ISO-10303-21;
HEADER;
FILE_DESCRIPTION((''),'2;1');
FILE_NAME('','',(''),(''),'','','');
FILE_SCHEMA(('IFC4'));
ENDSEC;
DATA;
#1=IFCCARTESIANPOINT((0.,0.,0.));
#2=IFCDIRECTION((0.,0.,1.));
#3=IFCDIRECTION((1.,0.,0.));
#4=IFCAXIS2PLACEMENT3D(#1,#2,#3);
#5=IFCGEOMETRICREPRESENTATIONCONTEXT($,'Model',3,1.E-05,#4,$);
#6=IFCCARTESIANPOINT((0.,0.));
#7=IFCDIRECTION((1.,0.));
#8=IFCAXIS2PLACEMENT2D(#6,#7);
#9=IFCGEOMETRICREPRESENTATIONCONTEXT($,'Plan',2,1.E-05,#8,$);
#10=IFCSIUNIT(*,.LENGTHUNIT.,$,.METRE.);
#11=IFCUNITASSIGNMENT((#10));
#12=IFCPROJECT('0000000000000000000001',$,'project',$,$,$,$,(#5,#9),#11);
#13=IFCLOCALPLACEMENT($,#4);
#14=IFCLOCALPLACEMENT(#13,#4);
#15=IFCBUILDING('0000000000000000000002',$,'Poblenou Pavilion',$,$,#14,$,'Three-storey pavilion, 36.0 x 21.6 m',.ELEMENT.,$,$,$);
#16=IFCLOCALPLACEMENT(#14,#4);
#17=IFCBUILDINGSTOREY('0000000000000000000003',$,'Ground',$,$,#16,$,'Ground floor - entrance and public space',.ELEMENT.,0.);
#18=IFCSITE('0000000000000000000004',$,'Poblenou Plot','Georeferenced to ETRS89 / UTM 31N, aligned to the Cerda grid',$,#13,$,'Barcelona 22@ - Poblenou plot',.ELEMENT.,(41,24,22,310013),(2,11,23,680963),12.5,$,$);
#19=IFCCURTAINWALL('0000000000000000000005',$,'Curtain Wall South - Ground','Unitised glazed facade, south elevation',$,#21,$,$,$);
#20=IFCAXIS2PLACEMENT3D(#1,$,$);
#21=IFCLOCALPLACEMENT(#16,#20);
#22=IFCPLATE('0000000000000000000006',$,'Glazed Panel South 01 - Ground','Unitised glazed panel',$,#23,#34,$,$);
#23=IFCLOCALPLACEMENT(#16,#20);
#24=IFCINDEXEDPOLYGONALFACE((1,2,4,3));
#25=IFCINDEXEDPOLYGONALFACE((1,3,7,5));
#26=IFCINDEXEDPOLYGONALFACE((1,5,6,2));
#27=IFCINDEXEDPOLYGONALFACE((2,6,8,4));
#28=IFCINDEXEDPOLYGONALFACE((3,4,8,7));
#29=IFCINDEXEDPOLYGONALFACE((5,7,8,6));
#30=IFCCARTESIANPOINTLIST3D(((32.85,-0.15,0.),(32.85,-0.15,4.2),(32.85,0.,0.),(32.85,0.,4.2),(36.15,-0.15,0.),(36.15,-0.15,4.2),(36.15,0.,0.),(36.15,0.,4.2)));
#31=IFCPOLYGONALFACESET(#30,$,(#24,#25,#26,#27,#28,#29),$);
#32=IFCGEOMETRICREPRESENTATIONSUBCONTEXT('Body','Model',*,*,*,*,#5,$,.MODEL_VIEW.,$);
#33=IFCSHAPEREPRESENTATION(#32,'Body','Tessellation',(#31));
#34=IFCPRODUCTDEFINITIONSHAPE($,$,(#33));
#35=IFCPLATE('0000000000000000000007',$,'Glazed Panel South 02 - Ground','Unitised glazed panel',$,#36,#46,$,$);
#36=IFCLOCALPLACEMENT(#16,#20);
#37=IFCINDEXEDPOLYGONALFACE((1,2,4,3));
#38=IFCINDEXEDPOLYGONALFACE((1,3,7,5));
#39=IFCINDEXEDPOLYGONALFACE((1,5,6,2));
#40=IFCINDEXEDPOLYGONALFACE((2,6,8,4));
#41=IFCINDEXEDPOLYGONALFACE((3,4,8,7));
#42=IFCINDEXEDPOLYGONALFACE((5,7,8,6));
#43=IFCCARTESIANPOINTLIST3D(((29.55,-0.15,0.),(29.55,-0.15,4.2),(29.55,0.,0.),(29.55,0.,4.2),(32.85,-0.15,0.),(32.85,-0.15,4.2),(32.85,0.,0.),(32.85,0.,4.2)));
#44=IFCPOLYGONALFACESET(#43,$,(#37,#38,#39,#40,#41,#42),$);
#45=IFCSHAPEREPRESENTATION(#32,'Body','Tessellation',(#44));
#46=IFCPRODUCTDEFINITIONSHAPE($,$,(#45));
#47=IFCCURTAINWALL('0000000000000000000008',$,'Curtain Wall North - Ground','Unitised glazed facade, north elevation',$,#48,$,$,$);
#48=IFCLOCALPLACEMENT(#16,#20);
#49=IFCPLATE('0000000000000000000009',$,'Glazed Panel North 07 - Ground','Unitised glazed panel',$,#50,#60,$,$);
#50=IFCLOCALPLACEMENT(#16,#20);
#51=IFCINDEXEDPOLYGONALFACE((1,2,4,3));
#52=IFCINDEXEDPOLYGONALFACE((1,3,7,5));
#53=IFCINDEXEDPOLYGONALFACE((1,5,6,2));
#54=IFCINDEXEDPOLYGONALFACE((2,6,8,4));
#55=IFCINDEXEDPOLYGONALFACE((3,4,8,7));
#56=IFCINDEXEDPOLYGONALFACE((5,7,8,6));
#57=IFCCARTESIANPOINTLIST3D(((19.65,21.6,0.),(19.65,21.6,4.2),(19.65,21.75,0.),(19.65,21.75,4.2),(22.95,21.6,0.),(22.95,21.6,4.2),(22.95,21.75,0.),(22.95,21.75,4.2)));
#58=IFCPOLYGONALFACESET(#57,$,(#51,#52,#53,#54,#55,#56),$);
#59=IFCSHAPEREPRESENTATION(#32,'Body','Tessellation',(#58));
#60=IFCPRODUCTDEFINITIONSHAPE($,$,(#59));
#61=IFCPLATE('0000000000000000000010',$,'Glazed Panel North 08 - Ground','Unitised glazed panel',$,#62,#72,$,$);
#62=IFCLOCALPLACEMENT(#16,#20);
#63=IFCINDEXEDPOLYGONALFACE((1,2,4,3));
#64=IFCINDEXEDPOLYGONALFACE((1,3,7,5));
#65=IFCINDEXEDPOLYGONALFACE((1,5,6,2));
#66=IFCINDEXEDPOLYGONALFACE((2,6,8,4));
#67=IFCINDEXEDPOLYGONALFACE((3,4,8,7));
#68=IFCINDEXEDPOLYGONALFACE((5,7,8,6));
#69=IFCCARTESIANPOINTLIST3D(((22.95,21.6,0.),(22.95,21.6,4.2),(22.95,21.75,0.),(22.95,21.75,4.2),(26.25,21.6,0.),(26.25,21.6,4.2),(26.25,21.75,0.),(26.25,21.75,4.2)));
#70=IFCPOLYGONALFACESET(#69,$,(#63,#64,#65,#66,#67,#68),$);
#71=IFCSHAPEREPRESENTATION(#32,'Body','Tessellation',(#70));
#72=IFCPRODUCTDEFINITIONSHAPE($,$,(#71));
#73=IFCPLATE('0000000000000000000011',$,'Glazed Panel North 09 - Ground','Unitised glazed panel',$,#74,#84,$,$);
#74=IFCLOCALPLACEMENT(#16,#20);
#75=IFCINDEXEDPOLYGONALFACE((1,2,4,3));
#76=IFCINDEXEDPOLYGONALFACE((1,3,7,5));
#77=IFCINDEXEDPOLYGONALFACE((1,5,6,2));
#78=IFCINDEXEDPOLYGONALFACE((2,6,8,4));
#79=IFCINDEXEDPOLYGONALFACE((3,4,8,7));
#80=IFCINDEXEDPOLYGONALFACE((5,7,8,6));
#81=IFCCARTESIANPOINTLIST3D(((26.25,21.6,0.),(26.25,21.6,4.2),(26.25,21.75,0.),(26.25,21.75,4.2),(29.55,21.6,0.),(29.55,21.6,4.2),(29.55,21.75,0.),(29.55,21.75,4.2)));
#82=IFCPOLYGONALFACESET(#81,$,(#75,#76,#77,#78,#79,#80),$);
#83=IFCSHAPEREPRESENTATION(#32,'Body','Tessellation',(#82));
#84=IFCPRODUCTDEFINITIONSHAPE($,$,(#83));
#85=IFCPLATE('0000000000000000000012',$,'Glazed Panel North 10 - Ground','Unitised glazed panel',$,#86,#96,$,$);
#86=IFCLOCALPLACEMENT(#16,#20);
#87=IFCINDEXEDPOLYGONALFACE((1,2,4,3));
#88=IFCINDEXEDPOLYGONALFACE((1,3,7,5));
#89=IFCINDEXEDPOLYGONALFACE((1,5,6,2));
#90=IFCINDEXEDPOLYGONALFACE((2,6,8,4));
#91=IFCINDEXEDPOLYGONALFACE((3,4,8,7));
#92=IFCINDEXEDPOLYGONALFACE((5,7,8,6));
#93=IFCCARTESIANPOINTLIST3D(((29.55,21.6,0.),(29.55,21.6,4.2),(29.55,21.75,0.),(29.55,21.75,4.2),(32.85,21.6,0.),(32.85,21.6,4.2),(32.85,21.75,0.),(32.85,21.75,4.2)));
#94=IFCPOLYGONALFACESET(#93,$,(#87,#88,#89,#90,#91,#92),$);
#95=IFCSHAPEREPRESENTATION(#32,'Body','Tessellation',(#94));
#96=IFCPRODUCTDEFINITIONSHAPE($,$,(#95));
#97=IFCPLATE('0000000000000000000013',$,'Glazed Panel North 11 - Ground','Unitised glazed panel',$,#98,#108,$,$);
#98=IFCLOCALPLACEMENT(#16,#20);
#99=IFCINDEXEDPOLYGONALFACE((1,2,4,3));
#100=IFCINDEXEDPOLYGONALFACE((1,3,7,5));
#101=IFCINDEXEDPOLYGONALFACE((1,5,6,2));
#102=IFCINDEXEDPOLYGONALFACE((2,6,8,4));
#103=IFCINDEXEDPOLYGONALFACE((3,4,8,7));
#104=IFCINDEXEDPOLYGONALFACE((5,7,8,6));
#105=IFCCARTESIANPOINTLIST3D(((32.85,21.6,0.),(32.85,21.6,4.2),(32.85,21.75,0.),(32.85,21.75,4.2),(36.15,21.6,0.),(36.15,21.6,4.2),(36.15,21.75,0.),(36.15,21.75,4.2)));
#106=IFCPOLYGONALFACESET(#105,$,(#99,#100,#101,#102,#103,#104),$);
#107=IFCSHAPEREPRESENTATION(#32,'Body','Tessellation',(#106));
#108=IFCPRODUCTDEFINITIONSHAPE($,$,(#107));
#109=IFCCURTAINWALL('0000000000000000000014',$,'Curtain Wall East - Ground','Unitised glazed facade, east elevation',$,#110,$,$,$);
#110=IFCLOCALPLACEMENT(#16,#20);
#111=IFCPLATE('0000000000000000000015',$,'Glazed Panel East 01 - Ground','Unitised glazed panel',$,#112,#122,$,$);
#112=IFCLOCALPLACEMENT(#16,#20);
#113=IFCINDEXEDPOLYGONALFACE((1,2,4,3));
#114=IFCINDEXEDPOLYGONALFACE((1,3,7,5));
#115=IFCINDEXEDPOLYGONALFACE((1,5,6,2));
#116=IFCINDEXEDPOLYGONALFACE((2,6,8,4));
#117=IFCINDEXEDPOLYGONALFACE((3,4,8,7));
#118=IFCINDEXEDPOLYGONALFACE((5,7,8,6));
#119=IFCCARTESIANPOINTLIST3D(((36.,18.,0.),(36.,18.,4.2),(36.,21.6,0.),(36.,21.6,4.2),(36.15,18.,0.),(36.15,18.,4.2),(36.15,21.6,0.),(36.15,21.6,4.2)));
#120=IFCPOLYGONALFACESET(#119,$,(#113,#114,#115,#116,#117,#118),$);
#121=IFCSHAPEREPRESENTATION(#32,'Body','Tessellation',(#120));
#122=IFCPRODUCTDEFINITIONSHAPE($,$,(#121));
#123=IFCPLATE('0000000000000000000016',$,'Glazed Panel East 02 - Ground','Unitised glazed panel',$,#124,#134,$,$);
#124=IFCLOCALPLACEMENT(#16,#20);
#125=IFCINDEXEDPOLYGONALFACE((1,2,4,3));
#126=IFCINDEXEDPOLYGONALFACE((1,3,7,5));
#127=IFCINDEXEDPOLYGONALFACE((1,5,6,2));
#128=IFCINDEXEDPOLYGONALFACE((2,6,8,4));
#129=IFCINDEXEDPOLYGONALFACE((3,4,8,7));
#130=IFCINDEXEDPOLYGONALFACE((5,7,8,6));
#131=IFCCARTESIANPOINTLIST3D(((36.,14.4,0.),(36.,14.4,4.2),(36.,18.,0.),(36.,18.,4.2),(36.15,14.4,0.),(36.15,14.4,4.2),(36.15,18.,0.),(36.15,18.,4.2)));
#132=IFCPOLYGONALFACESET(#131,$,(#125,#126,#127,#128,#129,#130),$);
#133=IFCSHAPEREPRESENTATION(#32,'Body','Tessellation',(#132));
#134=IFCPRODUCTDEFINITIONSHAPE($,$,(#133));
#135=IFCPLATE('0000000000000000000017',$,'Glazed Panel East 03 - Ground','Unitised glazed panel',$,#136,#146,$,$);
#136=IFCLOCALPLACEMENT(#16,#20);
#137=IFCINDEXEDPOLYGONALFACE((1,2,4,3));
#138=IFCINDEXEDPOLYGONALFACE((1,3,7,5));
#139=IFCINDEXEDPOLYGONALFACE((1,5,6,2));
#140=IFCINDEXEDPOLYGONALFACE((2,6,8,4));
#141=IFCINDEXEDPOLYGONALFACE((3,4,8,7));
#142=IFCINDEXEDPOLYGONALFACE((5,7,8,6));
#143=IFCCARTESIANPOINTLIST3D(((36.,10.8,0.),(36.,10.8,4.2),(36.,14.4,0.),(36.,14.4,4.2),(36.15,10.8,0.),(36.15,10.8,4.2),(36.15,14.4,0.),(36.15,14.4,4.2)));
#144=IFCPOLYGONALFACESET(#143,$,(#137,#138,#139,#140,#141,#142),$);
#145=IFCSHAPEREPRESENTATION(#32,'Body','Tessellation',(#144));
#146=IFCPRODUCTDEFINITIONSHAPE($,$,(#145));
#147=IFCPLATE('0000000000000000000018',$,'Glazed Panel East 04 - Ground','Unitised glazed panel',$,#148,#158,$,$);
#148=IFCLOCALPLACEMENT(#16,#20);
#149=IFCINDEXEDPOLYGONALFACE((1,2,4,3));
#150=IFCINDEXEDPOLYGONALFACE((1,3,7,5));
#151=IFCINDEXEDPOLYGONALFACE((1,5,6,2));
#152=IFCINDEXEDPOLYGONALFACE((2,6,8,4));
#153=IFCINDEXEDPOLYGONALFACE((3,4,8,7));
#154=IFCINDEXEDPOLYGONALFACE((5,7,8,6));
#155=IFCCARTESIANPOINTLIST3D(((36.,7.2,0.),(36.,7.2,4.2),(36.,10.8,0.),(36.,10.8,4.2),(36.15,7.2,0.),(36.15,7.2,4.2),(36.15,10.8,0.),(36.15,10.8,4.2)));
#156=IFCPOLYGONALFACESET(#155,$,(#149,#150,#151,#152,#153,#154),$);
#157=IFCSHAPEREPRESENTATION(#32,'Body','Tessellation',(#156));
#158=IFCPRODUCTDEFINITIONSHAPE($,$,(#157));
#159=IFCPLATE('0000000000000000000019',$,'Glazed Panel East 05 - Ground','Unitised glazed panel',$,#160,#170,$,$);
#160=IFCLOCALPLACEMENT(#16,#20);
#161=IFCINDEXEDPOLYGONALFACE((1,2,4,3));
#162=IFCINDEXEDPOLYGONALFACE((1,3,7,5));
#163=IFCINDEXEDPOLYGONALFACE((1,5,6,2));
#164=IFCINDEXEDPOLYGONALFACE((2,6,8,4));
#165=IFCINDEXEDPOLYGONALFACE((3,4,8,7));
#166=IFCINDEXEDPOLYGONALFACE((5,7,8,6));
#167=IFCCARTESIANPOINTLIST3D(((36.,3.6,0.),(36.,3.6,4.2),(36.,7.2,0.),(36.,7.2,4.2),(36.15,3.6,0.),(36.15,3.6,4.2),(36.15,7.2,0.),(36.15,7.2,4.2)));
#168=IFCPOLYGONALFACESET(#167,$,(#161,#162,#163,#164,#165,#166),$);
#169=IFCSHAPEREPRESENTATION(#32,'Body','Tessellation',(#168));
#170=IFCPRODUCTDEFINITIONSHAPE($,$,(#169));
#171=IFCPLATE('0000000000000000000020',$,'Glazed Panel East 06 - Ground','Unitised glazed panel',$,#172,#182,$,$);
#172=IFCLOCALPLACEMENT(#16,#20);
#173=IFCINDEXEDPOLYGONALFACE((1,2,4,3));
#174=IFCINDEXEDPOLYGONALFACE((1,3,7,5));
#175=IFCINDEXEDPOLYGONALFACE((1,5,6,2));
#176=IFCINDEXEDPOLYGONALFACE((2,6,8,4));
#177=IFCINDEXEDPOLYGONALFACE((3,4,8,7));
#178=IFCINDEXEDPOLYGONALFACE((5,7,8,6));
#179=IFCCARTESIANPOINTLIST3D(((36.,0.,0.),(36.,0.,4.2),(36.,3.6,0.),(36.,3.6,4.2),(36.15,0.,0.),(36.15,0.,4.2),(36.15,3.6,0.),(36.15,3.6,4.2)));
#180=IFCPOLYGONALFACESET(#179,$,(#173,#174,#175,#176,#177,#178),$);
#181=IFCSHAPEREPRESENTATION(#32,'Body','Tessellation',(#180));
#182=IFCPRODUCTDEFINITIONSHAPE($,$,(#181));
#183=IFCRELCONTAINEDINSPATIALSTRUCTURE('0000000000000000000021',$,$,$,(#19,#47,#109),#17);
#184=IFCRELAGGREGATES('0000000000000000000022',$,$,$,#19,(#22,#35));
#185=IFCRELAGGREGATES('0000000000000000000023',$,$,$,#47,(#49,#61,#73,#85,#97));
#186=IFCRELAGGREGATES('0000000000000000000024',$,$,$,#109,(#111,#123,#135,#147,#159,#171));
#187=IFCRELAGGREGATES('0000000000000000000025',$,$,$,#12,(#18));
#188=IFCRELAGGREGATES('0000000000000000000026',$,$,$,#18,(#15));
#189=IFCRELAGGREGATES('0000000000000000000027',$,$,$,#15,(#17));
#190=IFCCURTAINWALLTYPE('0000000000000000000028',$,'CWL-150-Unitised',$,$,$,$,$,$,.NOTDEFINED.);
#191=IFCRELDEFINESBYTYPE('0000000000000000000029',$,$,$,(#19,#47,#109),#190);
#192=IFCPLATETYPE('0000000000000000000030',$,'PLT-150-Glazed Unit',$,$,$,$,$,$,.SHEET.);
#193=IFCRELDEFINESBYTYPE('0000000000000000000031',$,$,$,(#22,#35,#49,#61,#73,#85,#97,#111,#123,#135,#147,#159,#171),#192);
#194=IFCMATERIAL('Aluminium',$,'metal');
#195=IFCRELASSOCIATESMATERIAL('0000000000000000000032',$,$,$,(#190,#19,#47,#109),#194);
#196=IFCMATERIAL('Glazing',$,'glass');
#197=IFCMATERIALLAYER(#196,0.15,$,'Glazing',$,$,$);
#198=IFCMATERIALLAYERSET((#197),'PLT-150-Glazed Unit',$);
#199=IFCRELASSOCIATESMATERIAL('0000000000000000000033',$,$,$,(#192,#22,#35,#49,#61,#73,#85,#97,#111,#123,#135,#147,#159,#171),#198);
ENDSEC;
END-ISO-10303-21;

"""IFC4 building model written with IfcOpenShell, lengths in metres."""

from ifc_helpers import new_model, si_unit, frame, origin_with_axes, origin_2d_with_axis, place, context, subcontext, project, spatial, line, indexed_curve, outline, extrude, material, layer, layer_set, layer_usage, type_object, element, aggregate, save


model = new_model("IFC4")

# Units and contexts
model_context = context("Model", 3, precision=1e-05, world=origin_with_axes())
plan_context = context("Plan", 2, precision=1e-05, world=origin_2d_with_axis())
body_context = subcontext(model_context, "Body", "Model", "MODEL_VIEW")
ifc_project = project(units=[si_unit("LENGTHUNIT", "METRE")], contexts=[model_context, plan_context])

# Site, building, storey
site_placement = place(None, origin_with_axes())
site = spatial("IfcSite", under=ifc_project, at=site_placement, Name="Poblenou Plot", Description="Georeferenced to ETRS89 / UTM 31N, aligned to the Cerda grid", LongName="Barcelona 22@ - Poblenou plot", CompositionType="ELEMENT", RefLatitude=(41, 24, 22, 310013), RefLongitude=(2, 11, 23, 680963), RefElevation=12.5)
building_placement = place(site_placement, origin_with_axes())
building = spatial("IfcBuilding", under=site, at=building_placement, Name="Poblenou Pavilion", LongName="Three-storey pavilion, 36.0 x 21.6 m", CompositionType="ELEMENT")
storey_placement = place(building_placement, origin_with_axes())
storey = spatial("IfcBuildingStorey", under=building, at=storey_placement, Name="Ground", LongName="Ground floor - entrance and public space", CompositionType="ELEMENT", Elevation=0.0)

# Curtain walls, plates
ifc_material_1 = material(Name="Aluminium", Category="metal")
curtain_wall_type = type_object("IfcCurtainWallType", Name="CWL-150-Unitised", PredefinedType="NOTDEFINED", material=ifc_material_1)
curtain_wall_1_placement = place(storey_placement, frame((36.15, 0.0, 0.0), z_axis=(0.0, 0.0, 1.0), x_axis=(-1.0, 0.0, 0.0)))
curtain_wall_1 = element("IfcCurtainWall", 1, at=curtain_wall_1_placement, inside=storey, type_object=curtain_wall_type, material=ifc_material_1, Name="Curtain Wall South - Ground", Description="Unitised glazed facade, south elevation")
ifc_material_2 = material(Name="Glazing", Category="glass")
ifc_layer_1 = layer(ifc_material_2, 0.15, Name="Glazing")
ifc_layer_set_1 = layer_set([ifc_layer_1], Name="PLT-150-Glazed Unit")
ifc_layer_usage_1 = layer_usage(ifc_layer_set_1, "AXIS2", "POSITIVE", 0.0)
plate_type = type_object("IfcPlateType", Name="PLT-150-Glazed Unit", PredefinedType="SHEET", material=ifc_layer_set_1)
plate_1_placement = place(curtain_wall_1_placement, origin_with_axes())
plate_1 = element("IfcPlate", 2, at=plate_1_placement, type_object=plate_type, material=ifc_layer_usage_1, Name="Glazed Panel South 01 - Ground", Description="Unitised glazed panel", context=body_context, shape_type="SweptSolid", body=[
    extrude(outline(indexed_curve([(0.0, 0.0), (3.3, 0.0), (3.3, 0.15), (0.0, 0.15)], segments=[line(1, 2, 3, 4, 1)])), origin_with_axes(), (0.0, 0.0, 1.0), 4.2),
])
ifc_layer_usage_2 = layer_usage(ifc_layer_set_1, "AXIS2", "POSITIVE", 0.0)
plate_2_placement = place(curtain_wall_1_placement, frame((3.3, 0.0, 0.0), z_axis=(0.0, 0.0, 1.0), x_axis=(1.0, 0.0, 0.0)))
plate_2 = element("IfcPlate", 3, at=plate_2_placement, type_object=plate_type, material=ifc_layer_usage_2, Name="Glazed Panel South 02 - Ground", Description="Unitised glazed panel", context=body_context, shape_type="SweptSolid", body=[
    extrude(outline(indexed_curve([(0.0, 0.0), (3.3, 0.0), (3.3, 0.15), (0.0, 0.15)], segments=[line(1, 2, 3, 4, 1)])), origin_with_axes(), (0.0, 0.0, 1.0), 4.2),
])
aggregate(curtain_wall_1, [plate_1, plate_2])
curtain_wall_2_placement = place(storey_placement, frame((-0.15, 21.6, 0.0), z_axis=(0.0, 0.0, 1.0), x_axis=(1.0, 0.0, 0.0)))
curtain_wall_2 = element("IfcCurtainWall", 4, at=curtain_wall_2_placement, inside=storey, type_object=curtain_wall_type, material=ifc_material_1, Name="Curtain Wall North - Ground", Description="Unitised glazed facade, north elevation")
ifc_layer_usage_3 = layer_usage(ifc_layer_set_1, "AXIS2", "POSITIVE", 0.0)
plate_3_placement = place(curtain_wall_2_placement, frame((19.8, 0.0, 0.0), z_axis=(0.0, 0.0, 1.0), x_axis=(1.0, 0.0, 0.0)))
plate_3 = element("IfcPlate", 5, at=plate_3_placement, type_object=plate_type, material=ifc_layer_usage_3, Name="Glazed Panel North 07 - Ground", Description="Unitised glazed panel", context=body_context, shape_type="SweptSolid", body=[
    extrude(outline(indexed_curve([(0.0, 0.0), (3.3, 0.0), (3.3, 0.15), (0.0, 0.15)], segments=[line(1, 2, 3, 4, 1)])), origin_with_axes(), (0.0, 0.0, 1.0), 4.2),
])
ifc_layer_usage_4 = layer_usage(ifc_layer_set_1, "AXIS2", "POSITIVE", 0.0)
plate_4_placement = place(curtain_wall_2_placement, frame((23.1, 0.0, 0.0), z_axis=(0.0, 0.0, 1.0), x_axis=(1.0, 0.0, 0.0)))
plate_4 = element("IfcPlate", 6, at=plate_4_placement, type_object=plate_type, material=ifc_layer_usage_4, Name="Glazed Panel North 08 - Ground", Description="Unitised glazed panel", context=body_context, shape_type="SweptSolid", body=[
    extrude(outline(indexed_curve([(0.0, 0.0), (3.3, 0.0), (3.3, 0.15), (0.0, 0.15)], segments=[line(1, 2, 3, 4, 1)])), origin_with_axes(), (0.0, 0.0, 1.0), 4.2),
])
ifc_layer_usage_5 = layer_usage(ifc_layer_set_1, "AXIS2", "POSITIVE", 0.0)
plate_5_placement = place(curtain_wall_2_placement, frame((26.4, 0.0, 0.0), z_axis=(0.0, 0.0, 1.0), x_axis=(1.0, 0.0, 0.0)))
plate_5 = element("IfcPlate", 7, at=plate_5_placement, type_object=plate_type, material=ifc_layer_usage_5, Name="Glazed Panel North 09 - Ground", Description="Unitised glazed panel", context=body_context, shape_type="SweptSolid", body=[
    extrude(outline(indexed_curve([(0.0, 0.0), (3.3, 0.0), (3.3, 0.15), (0.0, 0.15)], segments=[line(1, 2, 3, 4, 1)])), origin_with_axes(), (0.0, 0.0, 1.0), 4.2),
])
ifc_layer_usage_6 = layer_usage(ifc_layer_set_1, "AXIS2", "POSITIVE", 0.0)
plate_6_placement = place(curtain_wall_2_placement, frame((29.7, 0.0, 0.0), z_axis=(0.0, 0.0, 1.0), x_axis=(1.0, 0.0, 0.0)))
plate_6 = element("IfcPlate", 8, at=plate_6_placement, type_object=plate_type, material=ifc_layer_usage_6, Name="Glazed Panel North 10 - Ground", Description="Unitised glazed panel", context=body_context, shape_type="SweptSolid", body=[
    extrude(outline(indexed_curve([(0.0, 0.0), (3.3, 0.0), (3.3, 0.15), (0.0, 0.15)], segments=[line(1, 2, 3, 4, 1)])), origin_with_axes(), (0.0, 0.0, 1.0), 4.2),
])
ifc_layer_usage_7 = layer_usage(ifc_layer_set_1, "AXIS2", "POSITIVE", 0.0)
plate_7_placement = place(curtain_wall_2_placement, frame((33.0, 0.0, 0.0), z_axis=(0.0, 0.0, 1.0), x_axis=(1.0, 0.0, 0.0)))
plate_7 = element("IfcPlate", 9, at=plate_7_placement, type_object=plate_type, material=ifc_layer_usage_7, Name="Glazed Panel North 11 - Ground", Description="Unitised glazed panel", context=body_context, shape_type="SweptSolid", body=[
    extrude(outline(indexed_curve([(0.0, 0.0), (3.3, 0.0), (3.3, 0.15), (0.0, 0.15)], segments=[line(1, 2, 3, 4, 1)])), origin_with_axes(), (0.0, 0.0, 1.0), 4.2),
])
aggregate(curtain_wall_2, [plate_3, plate_4, plate_5, plate_6, plate_7])
curtain_wall_3_placement = place(storey_placement, frame((36.0, 21.6, 0.0), z_axis=(0.0, 0.0, 1.0), x_axis=(0.0, -1.0, 0.0)))
curtain_wall_3 = element("IfcCurtainWall", 10, at=curtain_wall_3_placement, inside=storey, type_object=curtain_wall_type, material=ifc_material_1, Name="Curtain Wall East - Ground", Description="Unitised glazed facade, east elevation")
ifc_layer_usage_8 = layer_usage(ifc_layer_set_1, "AXIS2", "POSITIVE", 0.0)
plate_8_placement = place(curtain_wall_3_placement, origin_with_axes())
plate_8 = element("IfcPlate", 11, at=plate_8_placement, type_object=plate_type, material=ifc_layer_usage_8, Name="Glazed Panel East 01 - Ground", Description="Unitised glazed panel", context=body_context, shape_type="SweptSolid", body=[
    extrude(outline(indexed_curve([(0.0, 0.0), (3.6, 0.0), (3.6, 0.15), (0.0, 0.15)], segments=[line(1, 2, 3, 4, 1)])), origin_with_axes(), (0.0, 0.0, 1.0), 4.2),
])
ifc_layer_usage_9 = layer_usage(ifc_layer_set_1, "AXIS2", "POSITIVE", 0.0)
plate_9_placement = place(curtain_wall_3_placement, frame((3.6, 0.0, 0.0), z_axis=(0.0, 0.0, 1.0), x_axis=(1.0, 0.0, 0.0)))
plate_9 = element("IfcPlate", 12, at=plate_9_placement, type_object=plate_type, material=ifc_layer_usage_9, Name="Glazed Panel East 02 - Ground", Description="Unitised glazed panel", context=body_context, shape_type="SweptSolid", body=[
    extrude(outline(indexed_curve([(0.0, 0.0), (3.6, 0.0), (3.6, 0.15), (0.0, 0.15)], segments=[line(1, 2, 3, 4, 1)])), origin_with_axes(), (0.0, 0.0, 1.0), 4.2),
])
ifc_layer_usage_10 = layer_usage(ifc_layer_set_1, "AXIS2", "POSITIVE", 0.0)
plate_10_placement = place(curtain_wall_3_placement, frame((7.2, 0.0, 0.0), z_axis=(0.0, 0.0, 1.0), x_axis=(1.0, 0.0, 0.0)))
plate_10 = element("IfcPlate", 13, at=plate_10_placement, type_object=plate_type, material=ifc_layer_usage_10, Name="Glazed Panel East 03 - Ground", Description="Unitised glazed panel", context=body_context, shape_type="SweptSolid", body=[
    extrude(outline(indexed_curve([(0.0, 0.0), (3.6, 0.0), (3.6, 0.15), (0.0, 0.15)], segments=[line(1, 2, 3, 4, 1)])), origin_with_axes(), (0.0, 0.0, 1.0), 4.2),
])
ifc_layer_usage_11 = layer_usage(ifc_layer_set_1, "AXIS2", "POSITIVE", 0.0)
plate_11_placement = place(curtain_wall_3_placement, frame((10.8, 0.0, 0.0), z_axis=(0.0, 0.0, 1.0), x_axis=(1.0, 0.0, 0.0)))
plate_11 = element("IfcPlate", 14, at=plate_11_placement, type_object=plate_type, material=ifc_layer_usage_11, Name="Glazed Panel East 04 - Ground", Description="Unitised glazed panel", context=body_context, shape_type="SweptSolid", body=[
    extrude(outline(indexed_curve([(0.0, 0.0), (3.6, 0.0), (3.6, 0.15), (0.0, 0.15)], segments=[line(1, 2, 3, 4, 1)])), origin_with_axes(), (0.0, 0.0, 1.0), 4.2),
])
ifc_layer_usage_12 = layer_usage(ifc_layer_set_1, "AXIS2", "POSITIVE", 0.0)
plate_12_placement = place(curtain_wall_3_placement, frame((14.4, 0.0, 0.0), z_axis=(0.0, 0.0, 1.0), x_axis=(1.0, 0.0, 0.0)))
plate_12 = element("IfcPlate", 15, at=plate_12_placement, type_object=plate_type, material=ifc_layer_usage_12, Name="Glazed Panel East 05 - Ground", Description="Unitised glazed panel", context=body_context, shape_type="SweptSolid", body=[
    extrude(outline(indexed_curve([(0.0, 0.0), (3.6, 0.0), (3.6, 0.15), (0.0, 0.15)], segments=[line(1, 2, 3, 4, 1)])), origin_with_axes(), (0.0, 0.0, 1.0), 4.2),
])
ifc_layer_usage_13 = layer_usage(ifc_layer_set_1, "AXIS2", "POSITIVE", 0.0)
plate_13_placement = place(curtain_wall_3_placement, frame((18.0, 0.0, 0.0), z_axis=(0.0, 0.0, 1.0), x_axis=(1.0, 0.0, 0.0)))
plate_13 = element("IfcPlate", 16, at=plate_13_placement, type_object=plate_type, material=ifc_layer_usage_13, Name="Glazed Panel East 06 - Ground", Description="Unitised glazed panel", context=body_context, shape_type="SweptSolid", body=[
    extrude(outline(indexed_curve([(0.0, 0.0), (3.6, 0.0), (3.6, 0.15), (0.0, 0.15)], segments=[line(1, 2, 3, 4, 1)])), origin_with_axes(), (0.0, 0.0, 1.0), 4.2),
])
aggregate(curtain_wall_3, [plate_8, plate_9, plate_10, plate_11, plate_12, plate_13])

save(model, "model.ifc")
